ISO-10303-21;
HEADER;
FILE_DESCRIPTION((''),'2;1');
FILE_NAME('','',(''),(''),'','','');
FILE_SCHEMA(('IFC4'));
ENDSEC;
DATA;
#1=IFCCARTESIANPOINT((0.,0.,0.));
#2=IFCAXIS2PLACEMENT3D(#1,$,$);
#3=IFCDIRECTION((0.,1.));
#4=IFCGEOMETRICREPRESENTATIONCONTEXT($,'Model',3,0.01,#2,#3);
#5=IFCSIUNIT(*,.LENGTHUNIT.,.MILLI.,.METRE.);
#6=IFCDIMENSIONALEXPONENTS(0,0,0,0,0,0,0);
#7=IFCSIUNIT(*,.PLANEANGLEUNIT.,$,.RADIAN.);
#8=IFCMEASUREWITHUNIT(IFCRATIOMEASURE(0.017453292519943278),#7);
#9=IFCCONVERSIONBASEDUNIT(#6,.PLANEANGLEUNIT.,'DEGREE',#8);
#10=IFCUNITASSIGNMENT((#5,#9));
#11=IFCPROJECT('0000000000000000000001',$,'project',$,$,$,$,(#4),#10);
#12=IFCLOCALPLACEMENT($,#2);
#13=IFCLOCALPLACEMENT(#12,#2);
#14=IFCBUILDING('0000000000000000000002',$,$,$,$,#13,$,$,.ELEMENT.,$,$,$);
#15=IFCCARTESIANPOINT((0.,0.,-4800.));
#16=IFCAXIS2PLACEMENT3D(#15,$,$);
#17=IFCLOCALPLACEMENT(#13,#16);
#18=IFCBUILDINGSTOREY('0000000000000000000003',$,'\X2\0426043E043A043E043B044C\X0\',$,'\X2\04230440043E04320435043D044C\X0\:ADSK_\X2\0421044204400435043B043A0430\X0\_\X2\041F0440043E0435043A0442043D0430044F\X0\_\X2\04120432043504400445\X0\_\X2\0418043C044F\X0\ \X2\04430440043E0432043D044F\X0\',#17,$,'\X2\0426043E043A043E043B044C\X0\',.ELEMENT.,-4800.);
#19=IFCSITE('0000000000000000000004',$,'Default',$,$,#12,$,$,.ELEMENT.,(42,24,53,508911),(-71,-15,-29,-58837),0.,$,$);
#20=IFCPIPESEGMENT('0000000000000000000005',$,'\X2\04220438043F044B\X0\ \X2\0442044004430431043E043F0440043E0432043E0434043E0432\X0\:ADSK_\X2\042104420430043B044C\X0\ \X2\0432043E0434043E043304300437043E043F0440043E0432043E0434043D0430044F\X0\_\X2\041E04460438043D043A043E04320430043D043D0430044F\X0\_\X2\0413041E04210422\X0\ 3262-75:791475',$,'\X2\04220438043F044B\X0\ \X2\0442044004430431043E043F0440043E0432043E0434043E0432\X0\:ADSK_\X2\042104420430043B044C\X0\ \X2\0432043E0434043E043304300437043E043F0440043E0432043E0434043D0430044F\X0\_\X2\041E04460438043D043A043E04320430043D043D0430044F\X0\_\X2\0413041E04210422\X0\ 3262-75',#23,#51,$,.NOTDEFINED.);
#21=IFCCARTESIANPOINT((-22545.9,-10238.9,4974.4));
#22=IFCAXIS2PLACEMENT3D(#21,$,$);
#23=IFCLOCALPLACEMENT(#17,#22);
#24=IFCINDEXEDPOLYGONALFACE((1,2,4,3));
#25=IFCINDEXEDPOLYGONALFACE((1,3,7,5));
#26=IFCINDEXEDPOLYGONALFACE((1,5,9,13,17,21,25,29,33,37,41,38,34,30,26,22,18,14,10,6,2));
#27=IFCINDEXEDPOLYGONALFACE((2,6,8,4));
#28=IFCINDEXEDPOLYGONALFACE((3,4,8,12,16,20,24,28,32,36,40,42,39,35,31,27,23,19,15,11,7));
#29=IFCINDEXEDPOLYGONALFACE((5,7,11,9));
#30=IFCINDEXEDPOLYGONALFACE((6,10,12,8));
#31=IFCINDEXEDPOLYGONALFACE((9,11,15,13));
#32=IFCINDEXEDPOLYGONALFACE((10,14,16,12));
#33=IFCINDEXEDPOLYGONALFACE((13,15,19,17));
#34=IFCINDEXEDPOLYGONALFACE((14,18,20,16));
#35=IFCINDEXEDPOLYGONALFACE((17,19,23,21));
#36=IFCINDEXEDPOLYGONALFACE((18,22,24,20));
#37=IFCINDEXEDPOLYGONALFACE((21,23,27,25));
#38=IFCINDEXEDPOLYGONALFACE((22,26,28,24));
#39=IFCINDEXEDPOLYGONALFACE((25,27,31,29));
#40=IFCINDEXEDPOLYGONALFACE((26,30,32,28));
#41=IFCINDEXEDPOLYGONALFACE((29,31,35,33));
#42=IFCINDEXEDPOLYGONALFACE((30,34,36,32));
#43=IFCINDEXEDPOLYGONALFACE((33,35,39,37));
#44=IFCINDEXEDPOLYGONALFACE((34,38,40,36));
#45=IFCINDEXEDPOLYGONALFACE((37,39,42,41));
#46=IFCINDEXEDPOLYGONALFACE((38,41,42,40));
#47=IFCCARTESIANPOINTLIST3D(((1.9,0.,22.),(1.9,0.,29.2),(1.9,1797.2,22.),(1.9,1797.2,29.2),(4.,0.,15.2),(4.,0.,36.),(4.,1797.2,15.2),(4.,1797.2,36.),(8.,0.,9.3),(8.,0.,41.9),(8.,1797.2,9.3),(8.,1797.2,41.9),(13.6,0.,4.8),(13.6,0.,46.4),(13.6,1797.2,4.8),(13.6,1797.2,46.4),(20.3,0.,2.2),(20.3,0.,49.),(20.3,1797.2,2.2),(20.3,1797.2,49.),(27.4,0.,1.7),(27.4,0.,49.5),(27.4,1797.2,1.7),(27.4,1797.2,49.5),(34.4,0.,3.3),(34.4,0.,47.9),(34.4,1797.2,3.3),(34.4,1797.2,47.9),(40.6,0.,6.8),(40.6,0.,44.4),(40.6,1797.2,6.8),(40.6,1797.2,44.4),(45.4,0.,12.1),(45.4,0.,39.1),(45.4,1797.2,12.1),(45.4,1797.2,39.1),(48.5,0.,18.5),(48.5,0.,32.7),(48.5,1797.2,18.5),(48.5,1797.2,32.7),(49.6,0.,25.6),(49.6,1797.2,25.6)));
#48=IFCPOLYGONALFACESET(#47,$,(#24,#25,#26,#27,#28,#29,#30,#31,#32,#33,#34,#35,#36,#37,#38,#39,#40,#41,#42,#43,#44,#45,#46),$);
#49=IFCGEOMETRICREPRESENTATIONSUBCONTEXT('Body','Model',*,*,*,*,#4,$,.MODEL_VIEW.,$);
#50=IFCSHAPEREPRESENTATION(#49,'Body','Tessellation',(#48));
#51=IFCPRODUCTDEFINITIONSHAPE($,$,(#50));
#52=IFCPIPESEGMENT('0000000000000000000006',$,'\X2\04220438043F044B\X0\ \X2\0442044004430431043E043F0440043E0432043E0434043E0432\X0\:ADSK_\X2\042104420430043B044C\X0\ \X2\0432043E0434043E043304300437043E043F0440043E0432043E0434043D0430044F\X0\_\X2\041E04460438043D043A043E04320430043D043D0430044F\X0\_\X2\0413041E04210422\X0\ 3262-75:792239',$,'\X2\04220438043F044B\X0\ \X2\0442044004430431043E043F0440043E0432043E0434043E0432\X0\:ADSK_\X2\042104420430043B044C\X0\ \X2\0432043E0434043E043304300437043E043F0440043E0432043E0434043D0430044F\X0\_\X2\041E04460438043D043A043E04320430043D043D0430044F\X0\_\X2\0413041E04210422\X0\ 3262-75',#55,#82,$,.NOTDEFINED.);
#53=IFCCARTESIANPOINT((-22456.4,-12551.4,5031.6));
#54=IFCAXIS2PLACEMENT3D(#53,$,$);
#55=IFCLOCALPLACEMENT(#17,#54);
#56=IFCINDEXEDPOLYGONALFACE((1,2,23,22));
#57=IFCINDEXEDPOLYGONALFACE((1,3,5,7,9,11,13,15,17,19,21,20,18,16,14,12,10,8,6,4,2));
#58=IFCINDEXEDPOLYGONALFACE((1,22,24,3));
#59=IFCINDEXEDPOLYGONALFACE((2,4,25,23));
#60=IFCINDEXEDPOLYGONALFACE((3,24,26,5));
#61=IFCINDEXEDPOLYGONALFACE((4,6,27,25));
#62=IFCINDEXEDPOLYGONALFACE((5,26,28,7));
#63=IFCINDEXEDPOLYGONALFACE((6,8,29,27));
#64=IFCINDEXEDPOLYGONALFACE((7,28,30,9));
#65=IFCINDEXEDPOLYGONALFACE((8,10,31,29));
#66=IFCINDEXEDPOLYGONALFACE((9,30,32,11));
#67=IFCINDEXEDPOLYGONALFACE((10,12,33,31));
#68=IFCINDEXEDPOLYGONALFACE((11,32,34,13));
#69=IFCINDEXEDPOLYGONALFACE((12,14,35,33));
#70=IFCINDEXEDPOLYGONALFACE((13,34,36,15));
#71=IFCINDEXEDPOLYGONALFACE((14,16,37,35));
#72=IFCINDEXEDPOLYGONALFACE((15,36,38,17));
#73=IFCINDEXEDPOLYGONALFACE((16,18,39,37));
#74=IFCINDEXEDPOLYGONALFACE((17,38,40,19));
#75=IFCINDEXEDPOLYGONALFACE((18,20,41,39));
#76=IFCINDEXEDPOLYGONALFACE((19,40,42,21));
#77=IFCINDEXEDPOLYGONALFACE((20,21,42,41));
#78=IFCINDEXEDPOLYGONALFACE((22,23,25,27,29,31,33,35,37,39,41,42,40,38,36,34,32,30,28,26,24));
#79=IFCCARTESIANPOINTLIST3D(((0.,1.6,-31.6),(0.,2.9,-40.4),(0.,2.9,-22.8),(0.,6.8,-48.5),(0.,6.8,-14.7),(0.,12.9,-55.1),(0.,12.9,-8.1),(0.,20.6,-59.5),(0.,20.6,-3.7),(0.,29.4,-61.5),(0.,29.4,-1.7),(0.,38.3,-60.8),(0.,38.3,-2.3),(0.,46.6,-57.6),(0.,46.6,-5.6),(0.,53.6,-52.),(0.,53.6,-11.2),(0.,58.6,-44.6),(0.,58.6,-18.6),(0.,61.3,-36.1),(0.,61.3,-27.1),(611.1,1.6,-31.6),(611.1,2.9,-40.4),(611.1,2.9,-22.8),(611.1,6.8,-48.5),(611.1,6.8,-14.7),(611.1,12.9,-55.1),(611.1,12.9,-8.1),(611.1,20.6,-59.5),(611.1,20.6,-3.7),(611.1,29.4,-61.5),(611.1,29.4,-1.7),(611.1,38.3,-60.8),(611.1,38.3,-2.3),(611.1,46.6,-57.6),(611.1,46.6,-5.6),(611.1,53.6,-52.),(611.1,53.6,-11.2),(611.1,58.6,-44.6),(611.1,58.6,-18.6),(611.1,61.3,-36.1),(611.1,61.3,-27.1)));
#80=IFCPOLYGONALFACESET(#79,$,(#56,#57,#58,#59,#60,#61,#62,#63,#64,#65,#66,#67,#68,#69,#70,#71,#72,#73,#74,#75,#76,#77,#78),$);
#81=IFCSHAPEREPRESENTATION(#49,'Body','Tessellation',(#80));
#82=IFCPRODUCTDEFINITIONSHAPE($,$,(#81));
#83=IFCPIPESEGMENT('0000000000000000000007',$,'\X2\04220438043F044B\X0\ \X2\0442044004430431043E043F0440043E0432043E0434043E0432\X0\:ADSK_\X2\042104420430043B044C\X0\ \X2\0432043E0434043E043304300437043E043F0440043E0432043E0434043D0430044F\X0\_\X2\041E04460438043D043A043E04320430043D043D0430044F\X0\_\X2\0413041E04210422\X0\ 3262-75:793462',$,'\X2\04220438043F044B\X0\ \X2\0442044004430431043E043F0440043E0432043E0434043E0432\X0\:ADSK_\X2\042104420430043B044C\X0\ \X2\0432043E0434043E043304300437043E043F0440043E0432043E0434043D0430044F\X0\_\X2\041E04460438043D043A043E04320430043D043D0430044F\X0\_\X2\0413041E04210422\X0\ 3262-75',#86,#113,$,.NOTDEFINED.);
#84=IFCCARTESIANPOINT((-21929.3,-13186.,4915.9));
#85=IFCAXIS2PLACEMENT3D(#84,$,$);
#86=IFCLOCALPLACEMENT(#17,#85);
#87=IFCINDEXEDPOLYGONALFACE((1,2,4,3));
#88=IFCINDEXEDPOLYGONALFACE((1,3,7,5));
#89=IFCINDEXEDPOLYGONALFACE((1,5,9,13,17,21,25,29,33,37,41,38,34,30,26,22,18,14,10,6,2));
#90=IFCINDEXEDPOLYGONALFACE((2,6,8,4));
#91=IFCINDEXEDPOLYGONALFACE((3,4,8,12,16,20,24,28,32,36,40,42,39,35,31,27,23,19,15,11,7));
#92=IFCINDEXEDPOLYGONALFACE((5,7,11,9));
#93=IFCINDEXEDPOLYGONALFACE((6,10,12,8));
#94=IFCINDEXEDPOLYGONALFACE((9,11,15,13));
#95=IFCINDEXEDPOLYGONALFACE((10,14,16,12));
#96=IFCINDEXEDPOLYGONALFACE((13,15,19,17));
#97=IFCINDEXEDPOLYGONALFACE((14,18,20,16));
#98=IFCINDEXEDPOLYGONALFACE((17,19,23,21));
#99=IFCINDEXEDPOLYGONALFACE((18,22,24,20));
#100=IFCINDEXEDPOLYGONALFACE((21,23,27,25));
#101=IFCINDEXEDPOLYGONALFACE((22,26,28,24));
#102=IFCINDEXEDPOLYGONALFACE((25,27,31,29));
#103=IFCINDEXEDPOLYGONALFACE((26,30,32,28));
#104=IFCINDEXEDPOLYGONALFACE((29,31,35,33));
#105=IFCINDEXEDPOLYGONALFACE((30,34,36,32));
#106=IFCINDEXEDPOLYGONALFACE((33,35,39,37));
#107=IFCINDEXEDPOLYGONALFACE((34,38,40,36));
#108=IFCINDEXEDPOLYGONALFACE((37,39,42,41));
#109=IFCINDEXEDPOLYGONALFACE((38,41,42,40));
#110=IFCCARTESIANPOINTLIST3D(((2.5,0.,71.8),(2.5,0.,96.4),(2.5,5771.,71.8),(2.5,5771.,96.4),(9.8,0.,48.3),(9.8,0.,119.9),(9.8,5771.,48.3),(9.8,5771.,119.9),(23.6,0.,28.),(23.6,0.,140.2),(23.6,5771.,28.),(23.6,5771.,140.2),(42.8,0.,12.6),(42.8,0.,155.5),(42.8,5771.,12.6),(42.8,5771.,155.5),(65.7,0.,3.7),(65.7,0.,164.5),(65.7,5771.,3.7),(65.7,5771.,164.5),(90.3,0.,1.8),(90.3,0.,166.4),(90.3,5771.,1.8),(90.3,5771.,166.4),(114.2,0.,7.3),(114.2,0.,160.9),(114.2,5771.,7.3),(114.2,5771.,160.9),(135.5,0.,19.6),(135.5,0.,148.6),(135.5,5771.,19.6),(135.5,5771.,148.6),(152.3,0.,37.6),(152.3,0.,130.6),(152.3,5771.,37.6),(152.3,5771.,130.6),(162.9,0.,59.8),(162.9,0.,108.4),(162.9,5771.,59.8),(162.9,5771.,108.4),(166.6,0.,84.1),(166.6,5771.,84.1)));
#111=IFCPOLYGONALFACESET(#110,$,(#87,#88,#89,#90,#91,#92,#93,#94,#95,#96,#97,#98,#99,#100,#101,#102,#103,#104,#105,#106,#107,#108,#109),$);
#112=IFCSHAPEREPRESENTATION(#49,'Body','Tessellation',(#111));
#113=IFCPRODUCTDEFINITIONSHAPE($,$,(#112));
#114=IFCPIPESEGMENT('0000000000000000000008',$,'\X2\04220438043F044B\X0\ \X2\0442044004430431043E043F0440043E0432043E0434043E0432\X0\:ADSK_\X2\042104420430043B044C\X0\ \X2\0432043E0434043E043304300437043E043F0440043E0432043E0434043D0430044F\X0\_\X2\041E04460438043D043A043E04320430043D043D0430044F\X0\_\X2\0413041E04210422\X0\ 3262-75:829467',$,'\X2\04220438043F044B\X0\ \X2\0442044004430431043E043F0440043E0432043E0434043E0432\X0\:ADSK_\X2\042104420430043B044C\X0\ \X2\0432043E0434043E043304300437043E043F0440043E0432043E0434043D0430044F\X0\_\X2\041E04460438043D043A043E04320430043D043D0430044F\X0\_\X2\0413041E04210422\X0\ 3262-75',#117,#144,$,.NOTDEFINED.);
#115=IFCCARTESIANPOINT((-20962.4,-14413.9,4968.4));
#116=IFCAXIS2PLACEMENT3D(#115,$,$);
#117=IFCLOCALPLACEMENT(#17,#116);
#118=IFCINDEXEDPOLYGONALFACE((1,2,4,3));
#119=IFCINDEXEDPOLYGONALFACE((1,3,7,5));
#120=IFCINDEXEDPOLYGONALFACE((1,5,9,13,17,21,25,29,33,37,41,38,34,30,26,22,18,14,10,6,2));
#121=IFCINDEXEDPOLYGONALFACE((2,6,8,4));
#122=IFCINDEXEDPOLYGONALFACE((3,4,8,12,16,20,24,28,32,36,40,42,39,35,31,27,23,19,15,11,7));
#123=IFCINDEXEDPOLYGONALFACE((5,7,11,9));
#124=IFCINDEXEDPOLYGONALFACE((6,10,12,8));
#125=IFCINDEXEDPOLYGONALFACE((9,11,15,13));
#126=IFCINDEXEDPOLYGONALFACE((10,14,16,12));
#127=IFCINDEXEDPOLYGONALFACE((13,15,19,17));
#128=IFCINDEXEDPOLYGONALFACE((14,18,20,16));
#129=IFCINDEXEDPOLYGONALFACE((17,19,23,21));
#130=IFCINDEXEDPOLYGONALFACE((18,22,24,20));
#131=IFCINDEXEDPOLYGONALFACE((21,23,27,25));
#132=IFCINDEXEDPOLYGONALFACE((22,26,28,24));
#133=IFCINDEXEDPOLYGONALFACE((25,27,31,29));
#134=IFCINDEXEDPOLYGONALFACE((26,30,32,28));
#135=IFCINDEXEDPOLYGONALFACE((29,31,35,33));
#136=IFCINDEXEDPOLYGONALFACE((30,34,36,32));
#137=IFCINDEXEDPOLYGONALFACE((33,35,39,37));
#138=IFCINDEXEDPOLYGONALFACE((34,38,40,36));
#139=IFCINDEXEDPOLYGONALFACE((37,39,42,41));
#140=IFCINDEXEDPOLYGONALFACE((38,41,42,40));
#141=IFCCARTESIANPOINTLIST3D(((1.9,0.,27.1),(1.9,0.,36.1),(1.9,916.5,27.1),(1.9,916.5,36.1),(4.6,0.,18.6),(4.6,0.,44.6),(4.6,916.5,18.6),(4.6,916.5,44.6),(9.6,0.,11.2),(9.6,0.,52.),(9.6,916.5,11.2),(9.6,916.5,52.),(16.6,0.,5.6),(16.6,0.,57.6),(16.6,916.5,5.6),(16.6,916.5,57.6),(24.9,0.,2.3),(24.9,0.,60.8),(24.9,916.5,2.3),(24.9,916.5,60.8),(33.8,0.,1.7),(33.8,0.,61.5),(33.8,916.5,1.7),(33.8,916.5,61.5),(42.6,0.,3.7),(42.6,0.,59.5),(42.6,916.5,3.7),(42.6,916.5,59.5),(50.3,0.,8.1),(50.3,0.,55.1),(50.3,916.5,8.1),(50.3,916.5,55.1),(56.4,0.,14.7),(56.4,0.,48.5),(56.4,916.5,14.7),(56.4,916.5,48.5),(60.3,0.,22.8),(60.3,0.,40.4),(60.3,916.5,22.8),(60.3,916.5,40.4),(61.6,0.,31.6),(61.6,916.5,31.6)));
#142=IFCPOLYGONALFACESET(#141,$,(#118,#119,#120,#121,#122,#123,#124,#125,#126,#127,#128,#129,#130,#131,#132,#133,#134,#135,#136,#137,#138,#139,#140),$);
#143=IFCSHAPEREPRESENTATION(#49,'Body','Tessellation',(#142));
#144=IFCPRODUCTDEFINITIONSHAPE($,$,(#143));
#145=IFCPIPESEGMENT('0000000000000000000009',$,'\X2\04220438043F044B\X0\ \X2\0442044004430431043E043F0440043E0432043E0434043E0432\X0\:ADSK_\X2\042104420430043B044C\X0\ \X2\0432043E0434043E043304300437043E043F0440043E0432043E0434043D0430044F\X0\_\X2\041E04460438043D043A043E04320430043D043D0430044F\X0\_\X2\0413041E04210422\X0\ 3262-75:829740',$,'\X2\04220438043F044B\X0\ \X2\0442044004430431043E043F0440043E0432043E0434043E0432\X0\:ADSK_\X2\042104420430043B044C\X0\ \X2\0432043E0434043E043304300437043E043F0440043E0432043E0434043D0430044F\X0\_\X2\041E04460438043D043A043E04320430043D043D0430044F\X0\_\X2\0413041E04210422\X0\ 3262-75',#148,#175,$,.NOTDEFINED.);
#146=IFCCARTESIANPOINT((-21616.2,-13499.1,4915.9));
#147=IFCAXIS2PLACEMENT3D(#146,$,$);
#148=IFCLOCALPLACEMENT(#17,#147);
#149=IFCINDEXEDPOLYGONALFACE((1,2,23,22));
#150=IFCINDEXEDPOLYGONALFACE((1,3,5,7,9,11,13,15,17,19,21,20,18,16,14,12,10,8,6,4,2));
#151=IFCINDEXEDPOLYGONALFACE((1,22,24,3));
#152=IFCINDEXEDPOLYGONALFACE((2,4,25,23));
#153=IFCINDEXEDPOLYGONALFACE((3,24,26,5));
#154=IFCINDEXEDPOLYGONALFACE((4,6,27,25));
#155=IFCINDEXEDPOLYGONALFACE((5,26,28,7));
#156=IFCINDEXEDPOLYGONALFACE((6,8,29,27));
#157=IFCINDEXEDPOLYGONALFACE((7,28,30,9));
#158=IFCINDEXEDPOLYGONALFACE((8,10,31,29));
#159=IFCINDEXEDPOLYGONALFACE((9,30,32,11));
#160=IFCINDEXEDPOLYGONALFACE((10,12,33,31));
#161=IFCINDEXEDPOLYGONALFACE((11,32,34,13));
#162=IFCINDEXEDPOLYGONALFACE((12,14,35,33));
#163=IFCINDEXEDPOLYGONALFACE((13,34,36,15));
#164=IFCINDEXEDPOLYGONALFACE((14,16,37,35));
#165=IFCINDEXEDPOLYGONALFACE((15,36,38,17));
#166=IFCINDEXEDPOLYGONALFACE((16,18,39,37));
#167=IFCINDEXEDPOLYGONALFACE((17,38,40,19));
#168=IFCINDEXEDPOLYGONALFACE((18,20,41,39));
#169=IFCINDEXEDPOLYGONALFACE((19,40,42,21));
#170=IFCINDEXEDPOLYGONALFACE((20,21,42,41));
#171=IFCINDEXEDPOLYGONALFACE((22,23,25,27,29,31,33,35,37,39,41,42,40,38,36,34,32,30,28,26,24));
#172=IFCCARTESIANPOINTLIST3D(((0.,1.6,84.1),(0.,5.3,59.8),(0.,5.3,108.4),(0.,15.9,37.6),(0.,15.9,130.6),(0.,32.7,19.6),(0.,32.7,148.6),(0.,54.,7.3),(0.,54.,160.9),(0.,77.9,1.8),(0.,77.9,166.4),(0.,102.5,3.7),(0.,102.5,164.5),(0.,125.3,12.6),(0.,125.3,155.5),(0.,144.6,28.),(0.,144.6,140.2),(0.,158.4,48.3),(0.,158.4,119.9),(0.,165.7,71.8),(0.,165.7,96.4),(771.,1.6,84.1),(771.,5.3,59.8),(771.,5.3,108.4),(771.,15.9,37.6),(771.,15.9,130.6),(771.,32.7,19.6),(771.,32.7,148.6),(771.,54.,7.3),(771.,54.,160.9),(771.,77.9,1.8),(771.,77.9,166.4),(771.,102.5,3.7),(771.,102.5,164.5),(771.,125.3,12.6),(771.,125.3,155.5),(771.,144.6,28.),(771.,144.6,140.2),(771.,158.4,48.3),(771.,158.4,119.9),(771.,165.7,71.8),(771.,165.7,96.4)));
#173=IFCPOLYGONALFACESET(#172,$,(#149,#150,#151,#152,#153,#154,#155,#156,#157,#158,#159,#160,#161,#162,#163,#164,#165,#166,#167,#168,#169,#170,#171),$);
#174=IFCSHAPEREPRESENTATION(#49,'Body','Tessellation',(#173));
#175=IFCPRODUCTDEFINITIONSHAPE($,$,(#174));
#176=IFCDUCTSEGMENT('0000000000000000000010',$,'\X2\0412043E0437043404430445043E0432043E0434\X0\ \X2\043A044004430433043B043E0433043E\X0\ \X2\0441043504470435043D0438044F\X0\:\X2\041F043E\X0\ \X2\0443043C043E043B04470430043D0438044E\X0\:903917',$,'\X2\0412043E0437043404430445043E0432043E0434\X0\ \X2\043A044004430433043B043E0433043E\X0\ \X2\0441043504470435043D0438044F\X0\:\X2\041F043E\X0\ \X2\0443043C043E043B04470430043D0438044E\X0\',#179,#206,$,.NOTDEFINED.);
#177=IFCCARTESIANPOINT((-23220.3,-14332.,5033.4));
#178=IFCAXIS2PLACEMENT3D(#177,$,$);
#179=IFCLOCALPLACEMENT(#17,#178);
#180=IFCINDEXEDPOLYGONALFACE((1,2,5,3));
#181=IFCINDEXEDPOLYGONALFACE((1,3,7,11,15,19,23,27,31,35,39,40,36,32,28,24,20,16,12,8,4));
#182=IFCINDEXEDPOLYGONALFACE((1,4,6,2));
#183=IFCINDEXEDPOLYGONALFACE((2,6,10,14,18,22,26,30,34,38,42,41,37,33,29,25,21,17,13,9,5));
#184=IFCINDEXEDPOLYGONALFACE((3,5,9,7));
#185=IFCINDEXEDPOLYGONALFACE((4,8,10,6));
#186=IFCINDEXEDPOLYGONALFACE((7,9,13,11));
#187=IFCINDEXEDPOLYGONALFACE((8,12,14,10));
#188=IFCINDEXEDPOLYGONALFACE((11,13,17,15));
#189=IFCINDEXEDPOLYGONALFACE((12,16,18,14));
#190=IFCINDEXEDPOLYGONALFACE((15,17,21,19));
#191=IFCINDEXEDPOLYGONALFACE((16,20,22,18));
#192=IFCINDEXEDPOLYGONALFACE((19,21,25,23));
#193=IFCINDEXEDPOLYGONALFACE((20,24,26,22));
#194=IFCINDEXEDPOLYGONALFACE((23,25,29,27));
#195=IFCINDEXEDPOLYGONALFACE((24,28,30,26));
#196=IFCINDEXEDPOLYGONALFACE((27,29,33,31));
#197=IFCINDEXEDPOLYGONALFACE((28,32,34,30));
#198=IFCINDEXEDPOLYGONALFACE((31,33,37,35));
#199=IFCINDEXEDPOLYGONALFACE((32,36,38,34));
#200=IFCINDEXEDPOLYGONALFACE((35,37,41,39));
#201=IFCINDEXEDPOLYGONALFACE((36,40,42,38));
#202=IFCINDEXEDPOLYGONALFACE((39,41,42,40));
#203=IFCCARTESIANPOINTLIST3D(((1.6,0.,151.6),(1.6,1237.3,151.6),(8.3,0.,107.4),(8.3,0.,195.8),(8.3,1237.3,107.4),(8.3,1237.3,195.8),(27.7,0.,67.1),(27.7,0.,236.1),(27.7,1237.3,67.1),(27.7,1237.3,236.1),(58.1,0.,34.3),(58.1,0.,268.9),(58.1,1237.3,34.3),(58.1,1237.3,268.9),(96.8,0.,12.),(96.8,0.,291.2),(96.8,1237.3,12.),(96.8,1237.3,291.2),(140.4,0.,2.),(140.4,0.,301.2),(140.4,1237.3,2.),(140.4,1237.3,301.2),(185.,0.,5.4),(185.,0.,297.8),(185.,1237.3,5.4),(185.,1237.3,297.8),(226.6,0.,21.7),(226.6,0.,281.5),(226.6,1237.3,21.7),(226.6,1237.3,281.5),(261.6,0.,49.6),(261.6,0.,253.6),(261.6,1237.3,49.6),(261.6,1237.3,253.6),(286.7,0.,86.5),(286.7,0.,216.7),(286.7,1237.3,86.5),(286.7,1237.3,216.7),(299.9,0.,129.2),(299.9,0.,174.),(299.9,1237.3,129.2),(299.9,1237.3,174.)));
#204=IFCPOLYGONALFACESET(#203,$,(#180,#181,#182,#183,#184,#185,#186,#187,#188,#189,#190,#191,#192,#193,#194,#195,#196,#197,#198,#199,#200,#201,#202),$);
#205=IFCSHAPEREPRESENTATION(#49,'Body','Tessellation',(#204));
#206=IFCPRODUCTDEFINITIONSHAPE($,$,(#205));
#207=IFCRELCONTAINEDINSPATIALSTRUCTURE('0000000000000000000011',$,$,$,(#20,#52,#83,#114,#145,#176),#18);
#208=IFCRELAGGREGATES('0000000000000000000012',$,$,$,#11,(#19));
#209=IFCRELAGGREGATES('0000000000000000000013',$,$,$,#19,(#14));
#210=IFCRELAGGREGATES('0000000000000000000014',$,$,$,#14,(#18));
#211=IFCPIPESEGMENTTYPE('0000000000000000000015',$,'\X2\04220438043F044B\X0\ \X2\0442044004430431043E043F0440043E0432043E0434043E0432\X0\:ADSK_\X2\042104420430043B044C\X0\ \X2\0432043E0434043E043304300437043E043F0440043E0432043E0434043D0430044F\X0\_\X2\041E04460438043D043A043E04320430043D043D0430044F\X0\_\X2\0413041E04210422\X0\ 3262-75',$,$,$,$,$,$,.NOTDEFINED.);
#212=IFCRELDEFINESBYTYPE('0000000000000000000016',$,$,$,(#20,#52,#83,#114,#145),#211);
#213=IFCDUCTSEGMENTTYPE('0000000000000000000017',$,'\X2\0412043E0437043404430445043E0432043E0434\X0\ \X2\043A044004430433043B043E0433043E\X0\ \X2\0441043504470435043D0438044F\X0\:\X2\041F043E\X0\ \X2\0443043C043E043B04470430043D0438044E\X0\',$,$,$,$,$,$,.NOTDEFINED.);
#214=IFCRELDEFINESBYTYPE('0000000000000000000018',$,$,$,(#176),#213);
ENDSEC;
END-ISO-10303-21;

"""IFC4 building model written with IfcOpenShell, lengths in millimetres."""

from ifc_helpers import new_model, entity, si_unit, converted_unit, direction, frame, frame_2d, origin, place, context, subcontext, project, spatial, circle, extrude, type_object, element, save


model = new_model("IFC4")

# Units and contexts
model_context = context("Model", 3, precision=0.01, world=origin(), true_north=direction((0.0, 1.0)))
body_context = subcontext(model_context, "Body", "Model", "MODEL_VIEW")
ifc_project = project(units=[si_unit("LENGTHUNIT", "METRE", prefix="MILLI"), converted_unit("PLANEANGLEUNIT", "DEGREE", entity("IfcRatioMeasure", 0.017453292519943278), si_unit("PLANEANGLEUNIT", "RADIAN"), dimensions=[0, 0, 0, 0, 0, 0, 0])], contexts=[model_context])

# Site, building, storey
site_placement = place(None, origin())
site = spatial("IfcSite", under=ifc_project, at=site_placement, Name="Default", CompositionType="ELEMENT", RefLatitude=(42, 24, 53, 508911), RefLongitude=(-71, -15, -29, -58837), RefElevation=0.0)
building_placement = place(site_placement, origin())
building = spatial("IfcBuilding", under=site, at=building_placement, CompositionType="ELEMENT")
storey_placement = place(building_placement, frame((0.0, 0.0, -4800.0)))
storey = spatial("IfcBuildingStorey", under=building, at=storey_placement, Name="Цоколь", ObjectType="Уровень:ADSK_Стрелка_Проектная_Вверх_Имя уровня", LongName="Цоколь", CompositionType="ELEMENT", Elevation=-4800.0)

# Pipe segments
pipe_segment_type = type_object("IfcPipeSegmentType", Name="Типы трубопроводов:ADSK_Сталь водогазопроводная_Оцинкованная_ГОСТ 3262-75", PredefinedType="NOTDEFINED")
pipe_segment_1_placement = place(storey_placement, frame((-22545.9, -10238.9, 4974.4)))
element("IfcPipeSegment", 1, at=pipe_segment_1_placement, inside=storey, type_object=pipe_segment_type, Name="Типы трубопроводов:ADSK_Сталь водогазопроводная_Оцинкованная_ГОСТ 3262-75:791475", ObjectType="Типы трубопроводов:ADSK_Сталь водогазопроводная_Оцинкованная_ГОСТ 3262-75", PredefinedType="NOTDEFINED", context=body_context, shape_type="SweptSolid", body=[
    extrude(circle(Radius=24.0, at=frame_2d((0.0, 0.0), x_axis=(1.0, 0.0))), frame((25.6, 0.0, 25.6), z_axis=(0.0, 1.0, 0.0), x_axis=(1.0, 0.0, 0.0)), (0.0, 0.0, 1.0), 1797.2),
])
pipe_segment_2_placement = place(storey_placement, frame((-22456.4, -12551.4, 5031.6)))
element("IfcPipeSegment", 2, at=pipe_segment_2_placement, inside=storey, type_object=pipe_segment_type, Name="Типы трубопроводов:ADSK_Сталь водогазопроводная_Оцинкованная_ГОСТ 3262-75:792239", ObjectType="Типы трубопроводов:ADSK_Сталь водогазопроводная_Оцинкованная_ГОСТ 3262-75", PredefinedType="NOTDEFINED", context=body_context, shape_type="SweptSolid", body=[
    extrude(circle(Radius=30.0, at=frame_2d((0.0, 0.0), x_axis=(1.0, 0.0))), frame((0.0, 31.6, -31.6), z_axis=(1.0, 0.0, 0.0), x_axis=(0.0, -1.0, 0.0)), (0.0, 0.0, 1.0), 611.1),
])
pipe_segment_3_placement = place(storey_placement, frame((-21929.3, -13186.0, 4915.9)))
element("IfcPipeSegment", 3, at=pipe_segment_3_placement, inside=storey, type_object=pipe_segment_type, Name="Типы трубопроводов:ADSK_Сталь водогазопроводная_Оцинкованная_ГОСТ 3262-75:793462", ObjectType="Типы трубопроводов:ADSK_Сталь водогазопроводная_Оцинкованная_ГОСТ 3262-75", PredefinedType="NOTDEFINED", context=body_context, shape_type="SweptSolid", body=[
    extrude(circle(Radius=82.5, at=frame_2d((0.0, 0.0), x_axis=(1.0, 0.0))), frame((84.1, 0.0, 84.1), z_axis=(0.0, 1.0, 0.0), x_axis=(1.0, 0.0, 0.0)), (0.0, 0.0, 1.0), 5771.0),
])
pipe_segment_4_placement = place(storey_placement, frame((-20962.4, -14413.9, 4968.4)))
element("IfcPipeSegment", 4, at=pipe_segment_4_placement, inside=storey, type_object=pipe_segment_type, Name="Типы трубопроводов:ADSK_Сталь водогазопроводная_Оцинкованная_ГОСТ 3262-75:829467", ObjectType="Типы трубопроводов:ADSK_Сталь водогазопроводная_Оцинкованная_ГОСТ 3262-75", PredefinedType="NOTDEFINED", context=body_context, shape_type="SweptSolid", body=[
    extrude(circle(Radius=30.0, at=frame_2d((0.0, 0.0), x_axis=(1.0, 0.0))), frame((31.6, 0.0, 31.6), z_axis=(0.0, 1.0, 0.0), x_axis=(1.0, 0.0, 0.0)), (0.0, 0.0, 1.0), 916.5),
])
pipe_segment_5_placement = place(storey_placement, frame((-21616.2, -13499.1, 4915.9)))
element("IfcPipeSegment", 5, at=pipe_segment_5_placement, inside=storey, type_object=pipe_segment_type, Name="Типы трубопроводов:ADSK_Сталь водогазопроводная_Оцинкованная_ГОСТ 3262-75:829740", ObjectType="Типы трубопроводов:ADSK_Сталь водогазопроводная_Оцинкованная_ГОСТ 3262-75", PredefinedType="NOTDEFINED", context=body_context, shape_type="SweptSolid", body=[
    extrude(circle(Radius=82.5, at=frame_2d((0.0, 0.0), x_axis=(1.0, 0.0))), frame((0.0, 84.1, 84.1), z_axis=(1.0, 0.0, 0.0), x_axis=(0.0, -1.0, 0.0)), (0.0, 0.0, 1.0), 771.0),
])

# Duct segment
duct_segment_type = type_object("IfcDuctSegmentType", Name="Воздуховод круглого сечения:По умолчанию", PredefinedType="NOTDEFINED")
duct_segment_1_placement = place(storey_placement, frame((-23220.3, -14332.0, 5033.4)))
element("IfcDuctSegment", 6, at=duct_segment_1_placement, inside=storey, type_object=duct_segment_type, Name="Воздуховод круглого сечения:По умолчанию:903917", ObjectType="Воздуховод круглого сечения:По умолчанию", PredefinedType="NOTDEFINED", context=body_context, shape_type="SweptSolid", body=[
    extrude(circle(Radius=150.0, at=frame_2d((0.0, 0.0), x_axis=(1.0, 0.0))), frame((151.6, 0.0, 151.6), z_axis=(0.0, 1.0, 0.0), x_axis=(-1.0, 0.0, 0.0)), (0.0, 0.0, 1.0), 1237.3),
])

save(model, "model.ifc")
